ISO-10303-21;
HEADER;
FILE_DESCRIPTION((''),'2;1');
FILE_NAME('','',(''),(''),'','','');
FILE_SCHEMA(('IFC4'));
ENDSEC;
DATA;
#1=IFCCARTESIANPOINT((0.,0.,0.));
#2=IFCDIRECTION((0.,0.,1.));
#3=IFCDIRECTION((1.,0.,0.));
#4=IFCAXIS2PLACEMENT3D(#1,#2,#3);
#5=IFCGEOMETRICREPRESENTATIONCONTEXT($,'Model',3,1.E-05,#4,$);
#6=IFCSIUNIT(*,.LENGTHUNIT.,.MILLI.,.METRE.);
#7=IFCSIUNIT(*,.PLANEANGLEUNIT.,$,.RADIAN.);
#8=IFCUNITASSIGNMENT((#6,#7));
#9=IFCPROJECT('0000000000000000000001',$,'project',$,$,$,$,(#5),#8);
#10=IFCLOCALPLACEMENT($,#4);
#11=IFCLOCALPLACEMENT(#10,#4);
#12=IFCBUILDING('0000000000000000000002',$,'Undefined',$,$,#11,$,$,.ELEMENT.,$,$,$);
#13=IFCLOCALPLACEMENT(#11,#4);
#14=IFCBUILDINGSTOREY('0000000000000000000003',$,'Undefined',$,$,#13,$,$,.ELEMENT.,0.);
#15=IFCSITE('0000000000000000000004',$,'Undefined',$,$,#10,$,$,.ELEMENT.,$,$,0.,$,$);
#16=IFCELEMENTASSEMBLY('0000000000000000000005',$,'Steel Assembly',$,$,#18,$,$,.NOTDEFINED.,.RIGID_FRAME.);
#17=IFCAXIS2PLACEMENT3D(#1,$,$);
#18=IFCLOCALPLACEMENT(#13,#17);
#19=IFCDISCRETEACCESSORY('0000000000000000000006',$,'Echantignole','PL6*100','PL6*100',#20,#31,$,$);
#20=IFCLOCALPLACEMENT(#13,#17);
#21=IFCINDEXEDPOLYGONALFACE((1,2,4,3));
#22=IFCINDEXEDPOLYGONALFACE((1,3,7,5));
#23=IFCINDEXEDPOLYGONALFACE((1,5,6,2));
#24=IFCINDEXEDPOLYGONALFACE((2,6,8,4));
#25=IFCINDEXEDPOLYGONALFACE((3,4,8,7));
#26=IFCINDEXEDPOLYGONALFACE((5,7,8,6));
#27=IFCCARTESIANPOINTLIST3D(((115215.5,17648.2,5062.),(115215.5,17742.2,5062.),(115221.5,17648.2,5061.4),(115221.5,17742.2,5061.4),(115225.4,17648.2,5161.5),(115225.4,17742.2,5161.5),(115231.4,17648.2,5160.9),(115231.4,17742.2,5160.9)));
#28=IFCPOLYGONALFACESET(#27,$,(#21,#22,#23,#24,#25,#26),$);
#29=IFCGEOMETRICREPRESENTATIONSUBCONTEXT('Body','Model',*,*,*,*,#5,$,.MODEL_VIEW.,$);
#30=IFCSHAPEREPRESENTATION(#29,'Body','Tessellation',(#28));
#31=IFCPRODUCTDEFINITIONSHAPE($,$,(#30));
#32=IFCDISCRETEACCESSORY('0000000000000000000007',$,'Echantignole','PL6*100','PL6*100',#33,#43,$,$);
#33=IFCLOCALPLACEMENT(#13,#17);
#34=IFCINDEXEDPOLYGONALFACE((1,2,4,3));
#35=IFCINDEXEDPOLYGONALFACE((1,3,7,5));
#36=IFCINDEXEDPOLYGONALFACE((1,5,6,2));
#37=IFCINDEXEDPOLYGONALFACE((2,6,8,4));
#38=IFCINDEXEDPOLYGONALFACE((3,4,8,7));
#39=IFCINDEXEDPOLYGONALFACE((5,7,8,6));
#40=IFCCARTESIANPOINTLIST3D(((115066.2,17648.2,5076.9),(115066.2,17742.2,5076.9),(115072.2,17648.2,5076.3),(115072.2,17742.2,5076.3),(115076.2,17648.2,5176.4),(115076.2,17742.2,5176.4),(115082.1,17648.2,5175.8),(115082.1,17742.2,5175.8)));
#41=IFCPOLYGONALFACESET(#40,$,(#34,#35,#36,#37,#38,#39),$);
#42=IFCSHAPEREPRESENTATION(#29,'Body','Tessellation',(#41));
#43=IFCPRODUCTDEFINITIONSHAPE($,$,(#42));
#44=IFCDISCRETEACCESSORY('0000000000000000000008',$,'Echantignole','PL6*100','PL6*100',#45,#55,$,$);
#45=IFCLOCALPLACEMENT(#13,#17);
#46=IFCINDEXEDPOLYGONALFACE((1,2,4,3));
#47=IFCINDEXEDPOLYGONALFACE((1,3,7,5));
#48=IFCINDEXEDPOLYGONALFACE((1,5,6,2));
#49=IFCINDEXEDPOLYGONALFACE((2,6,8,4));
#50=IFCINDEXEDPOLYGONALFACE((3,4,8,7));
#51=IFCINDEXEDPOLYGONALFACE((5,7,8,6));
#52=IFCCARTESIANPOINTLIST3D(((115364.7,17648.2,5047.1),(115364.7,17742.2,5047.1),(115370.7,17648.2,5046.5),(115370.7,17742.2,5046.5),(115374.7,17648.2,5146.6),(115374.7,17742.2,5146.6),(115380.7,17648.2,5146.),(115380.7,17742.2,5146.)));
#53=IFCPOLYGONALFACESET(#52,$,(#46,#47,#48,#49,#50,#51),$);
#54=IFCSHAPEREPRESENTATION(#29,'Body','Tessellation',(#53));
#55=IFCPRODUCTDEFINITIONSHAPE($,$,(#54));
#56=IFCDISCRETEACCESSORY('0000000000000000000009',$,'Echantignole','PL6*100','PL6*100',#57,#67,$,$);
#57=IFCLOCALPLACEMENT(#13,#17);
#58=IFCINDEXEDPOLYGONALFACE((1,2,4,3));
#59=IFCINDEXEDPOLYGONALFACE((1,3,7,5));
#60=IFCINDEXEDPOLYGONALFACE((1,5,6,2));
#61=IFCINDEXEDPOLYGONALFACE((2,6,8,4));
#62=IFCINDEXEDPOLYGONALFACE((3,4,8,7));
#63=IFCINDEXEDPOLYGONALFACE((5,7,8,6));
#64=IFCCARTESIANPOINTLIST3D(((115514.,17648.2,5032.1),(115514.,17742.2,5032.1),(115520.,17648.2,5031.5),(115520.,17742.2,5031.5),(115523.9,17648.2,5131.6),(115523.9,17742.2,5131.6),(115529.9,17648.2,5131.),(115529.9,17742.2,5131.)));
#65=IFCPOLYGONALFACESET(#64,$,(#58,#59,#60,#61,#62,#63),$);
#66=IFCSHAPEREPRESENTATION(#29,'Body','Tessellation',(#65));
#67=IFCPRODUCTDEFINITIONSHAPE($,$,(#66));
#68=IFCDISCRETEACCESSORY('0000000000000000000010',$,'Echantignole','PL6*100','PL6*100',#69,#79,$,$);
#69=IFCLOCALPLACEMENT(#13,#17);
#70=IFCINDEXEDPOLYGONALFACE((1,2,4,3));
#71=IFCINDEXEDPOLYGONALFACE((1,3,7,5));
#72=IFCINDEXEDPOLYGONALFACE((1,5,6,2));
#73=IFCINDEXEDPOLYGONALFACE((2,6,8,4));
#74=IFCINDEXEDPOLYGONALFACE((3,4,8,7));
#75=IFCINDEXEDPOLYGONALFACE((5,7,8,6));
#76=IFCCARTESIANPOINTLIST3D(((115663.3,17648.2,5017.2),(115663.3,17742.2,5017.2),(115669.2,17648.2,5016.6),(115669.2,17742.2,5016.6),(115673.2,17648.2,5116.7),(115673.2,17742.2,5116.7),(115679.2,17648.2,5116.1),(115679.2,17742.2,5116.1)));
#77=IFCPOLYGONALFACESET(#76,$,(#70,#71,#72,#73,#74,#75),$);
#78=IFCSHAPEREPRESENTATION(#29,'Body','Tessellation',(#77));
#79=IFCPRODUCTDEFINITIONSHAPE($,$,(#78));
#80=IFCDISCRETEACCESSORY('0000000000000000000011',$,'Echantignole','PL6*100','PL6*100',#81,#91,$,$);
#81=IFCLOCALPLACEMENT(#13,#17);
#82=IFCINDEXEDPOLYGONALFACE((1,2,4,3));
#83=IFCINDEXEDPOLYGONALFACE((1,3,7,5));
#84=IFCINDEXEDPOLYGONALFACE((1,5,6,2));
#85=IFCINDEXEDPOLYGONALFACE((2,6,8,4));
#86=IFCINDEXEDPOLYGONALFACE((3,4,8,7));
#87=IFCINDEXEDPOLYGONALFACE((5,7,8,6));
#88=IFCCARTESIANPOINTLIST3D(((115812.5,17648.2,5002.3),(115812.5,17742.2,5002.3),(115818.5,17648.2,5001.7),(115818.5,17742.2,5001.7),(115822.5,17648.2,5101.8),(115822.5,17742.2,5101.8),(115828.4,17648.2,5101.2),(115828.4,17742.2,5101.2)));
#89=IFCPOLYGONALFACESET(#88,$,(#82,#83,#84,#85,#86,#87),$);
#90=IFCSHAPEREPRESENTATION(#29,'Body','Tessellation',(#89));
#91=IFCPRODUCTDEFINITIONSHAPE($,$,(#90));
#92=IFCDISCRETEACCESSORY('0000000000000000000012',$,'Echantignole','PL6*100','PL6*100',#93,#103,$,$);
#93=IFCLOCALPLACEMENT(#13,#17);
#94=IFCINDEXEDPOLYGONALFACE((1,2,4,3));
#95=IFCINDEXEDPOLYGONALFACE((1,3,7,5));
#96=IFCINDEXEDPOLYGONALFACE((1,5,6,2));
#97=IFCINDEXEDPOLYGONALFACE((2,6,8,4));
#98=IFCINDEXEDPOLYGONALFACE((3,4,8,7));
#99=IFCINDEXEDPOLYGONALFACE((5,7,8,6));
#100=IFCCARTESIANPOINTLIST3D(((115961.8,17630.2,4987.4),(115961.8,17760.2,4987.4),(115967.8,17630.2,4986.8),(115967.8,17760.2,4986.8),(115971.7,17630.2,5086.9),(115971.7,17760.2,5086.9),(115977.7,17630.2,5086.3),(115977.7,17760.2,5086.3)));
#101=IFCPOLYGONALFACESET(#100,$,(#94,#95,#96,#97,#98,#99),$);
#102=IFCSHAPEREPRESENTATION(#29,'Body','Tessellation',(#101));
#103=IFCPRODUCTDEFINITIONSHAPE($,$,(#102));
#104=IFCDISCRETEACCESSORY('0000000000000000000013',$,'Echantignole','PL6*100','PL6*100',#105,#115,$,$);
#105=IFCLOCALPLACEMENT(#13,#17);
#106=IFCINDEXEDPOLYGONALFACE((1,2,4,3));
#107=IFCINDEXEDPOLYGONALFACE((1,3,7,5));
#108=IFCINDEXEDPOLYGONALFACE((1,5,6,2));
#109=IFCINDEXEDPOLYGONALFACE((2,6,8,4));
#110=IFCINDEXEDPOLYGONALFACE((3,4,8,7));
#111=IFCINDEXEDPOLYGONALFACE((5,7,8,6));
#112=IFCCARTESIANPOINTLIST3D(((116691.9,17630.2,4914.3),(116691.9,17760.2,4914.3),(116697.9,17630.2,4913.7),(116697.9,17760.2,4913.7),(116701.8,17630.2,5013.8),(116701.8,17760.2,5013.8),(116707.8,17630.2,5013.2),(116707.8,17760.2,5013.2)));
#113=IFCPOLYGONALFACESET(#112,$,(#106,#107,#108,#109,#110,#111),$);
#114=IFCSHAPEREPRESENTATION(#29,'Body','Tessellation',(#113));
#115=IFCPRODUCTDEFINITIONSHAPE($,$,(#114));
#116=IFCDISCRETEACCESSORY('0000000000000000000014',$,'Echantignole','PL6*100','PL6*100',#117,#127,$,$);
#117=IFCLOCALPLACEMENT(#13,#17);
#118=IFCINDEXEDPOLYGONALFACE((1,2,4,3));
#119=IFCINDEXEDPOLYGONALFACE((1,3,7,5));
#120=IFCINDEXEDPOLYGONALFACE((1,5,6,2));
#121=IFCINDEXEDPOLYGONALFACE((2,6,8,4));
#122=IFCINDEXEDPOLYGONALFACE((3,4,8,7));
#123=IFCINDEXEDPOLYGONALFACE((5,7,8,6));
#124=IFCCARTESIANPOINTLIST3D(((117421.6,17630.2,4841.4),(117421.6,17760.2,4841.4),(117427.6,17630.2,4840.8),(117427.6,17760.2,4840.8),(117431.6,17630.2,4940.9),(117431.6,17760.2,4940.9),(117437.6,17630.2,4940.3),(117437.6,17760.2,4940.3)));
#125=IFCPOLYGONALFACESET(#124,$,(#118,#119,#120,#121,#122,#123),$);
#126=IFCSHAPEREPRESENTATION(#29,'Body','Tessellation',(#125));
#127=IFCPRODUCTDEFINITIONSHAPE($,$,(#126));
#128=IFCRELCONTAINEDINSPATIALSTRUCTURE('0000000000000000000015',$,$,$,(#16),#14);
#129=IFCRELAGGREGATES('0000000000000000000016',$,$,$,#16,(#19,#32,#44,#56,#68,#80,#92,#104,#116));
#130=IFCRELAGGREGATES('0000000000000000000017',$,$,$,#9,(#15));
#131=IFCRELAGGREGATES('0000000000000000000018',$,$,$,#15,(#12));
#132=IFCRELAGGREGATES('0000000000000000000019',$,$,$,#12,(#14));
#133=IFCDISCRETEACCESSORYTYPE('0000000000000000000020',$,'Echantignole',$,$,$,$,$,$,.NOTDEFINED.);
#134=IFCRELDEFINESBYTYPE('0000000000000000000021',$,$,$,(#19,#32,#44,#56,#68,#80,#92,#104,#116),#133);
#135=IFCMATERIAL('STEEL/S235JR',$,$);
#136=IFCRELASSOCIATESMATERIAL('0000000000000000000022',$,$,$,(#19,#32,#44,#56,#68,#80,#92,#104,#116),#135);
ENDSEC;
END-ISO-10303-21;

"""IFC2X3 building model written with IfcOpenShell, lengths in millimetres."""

from ifc_helpers import new_model, si_unit, frame, origin_with_axes, place, context, subcontext, project, spatial, polyline, outline, extrude, material, type_object, element, aggregate, save


model = new_model("IFC2X3")

# Units and contexts
model_context = context("Model", 3, precision=1e-05, world=origin_with_axes())
body_context = subcontext(model_context, "Body", "Model", "MODEL_VIEW")
ifc_project = project(units=[si_unit("LENGTHUNIT", "METRE", prefix="MILLI"), si_unit("PLANEANGLEUNIT", "RADIAN")], contexts=[model_context])

# Site, building, storey
site_placement = place(None, origin_with_axes())
site = spatial("IfcSite", under=ifc_project, at=site_placement, Name="Undefined", CompositionType="ELEMENT", RefElevation=0.0)
building_placement = place(site_placement, origin_with_axes())
building = spatial("IfcBuilding", under=site, at=building_placement, Name="Undefined", CompositionType="ELEMENT")
storey_placement = place(building_placement, origin_with_axes())
storey = spatial("IfcBuildingStorey", under=building, at=storey_placement, Name="Undefined", CompositionType="ELEMENT", Elevation=0.0)

# Element assembly, discrete accessories
assembly_1_placement = place(storey_placement, origin_with_axes())
assembly_1 = element("IfcElementAssembly", 1, at=assembly_1_placement, inside=storey, Name="Steel Assembly", AssemblyPlace="NOTDEFINED", PredefinedType="RIGID_FRAME")
ifc_material_1 = material(Name="STEEL/S235JR")
discrete_accessory_type_1 = type_object("IfcDiscreteAccessoryType", Name="Echantignole")
discrete_accessory_1_placement = place(assembly_1_placement, frame((115223.4, 17648.2, 5111.4), z_axis=(0.995037, 0.0, -0.099504), x_axis=(0.0, 1.0, 0.000001)))
discrete_accessory_1 = element("IfcDiscreteAccessory", 2, at=discrete_accessory_1_placement, type_object=discrete_accessory_type_1, material=ifc_material_1, Name="Echantignole", Description="PL6*100", ObjectType="PL6*100", context=body_context, shape_type="SweptSolid", body=[
    extrude(outline(polyline([(0.0, 50.0), (94.0, 50.0), (94.0, -50.0), (0.0, -50.0), (0.0, 50.0)])), frame((0.0, 0.0, -3.0), z_axis=(0.0, 0.0, 1.0), x_axis=(1.0, 0.0, 0.0)), (0.0, 0.0, 1.0), 6.0),
])
discrete_accessory_2_placement = place(assembly_1_placement, frame((115074.2, 17648.2, 5126.4), z_axis=(0.995037, 0.0, -0.099504), x_axis=(0.0, 1.0, 0.000001)))
discrete_accessory_2 = element("IfcDiscreteAccessory", 3, at=discrete_accessory_2_placement, type_object=discrete_accessory_type_1, material=ifc_material_1, Name="Echantignole", Description="PL6*100", ObjectType="PL6*100", context=body_context, shape_type="SweptSolid", body=[
    extrude(outline(polyline([(0.0, 50.0), (94.0, 50.0), (94.0, -50.0), (0.0, -50.0), (0.0, 50.0)])), frame((0.0, 0.0, -3.0), z_axis=(0.0, 0.0, 1.0), x_axis=(1.0, 0.0, 0.0)), (0.0, 0.0, 1.0), 6.0),
])
discrete_accessory_3_placement = place(assembly_1_placement, frame((115372.7, 17648.2, 5096.5), z_axis=(0.995037, 0.0, -0.099504), x_axis=(0.0, 1.0, 0.000001)))
discrete_accessory_3 = element("IfcDiscreteAccessory", 4, at=discrete_accessory_3_placement, type_object=discrete_accessory_type_1, material=ifc_material_1, Name="Echantignole", Description="PL6*100", ObjectType="PL6*100", context=body_context, shape_type="SweptSolid", body=[
    extrude(outline(polyline([(0.0, 50.0), (94.0, 50.0), (94.0, -50.0), (0.0, -50.0), (0.0, 50.0)])), frame((0.0, 0.0, -3.0), z_axis=(0.0, 0.0, 1.0), x_axis=(1.0, 0.0, 0.0)), (0.0, 0.0, 1.0), 6.0),
])
discrete_accessory_4_placement = place(assembly_1_placement, frame((115522.0, 17648.2, 5081.6), z_axis=(0.995037, 0.0, -0.099504), x_axis=(0.0, 1.0, 0.000001)))
discrete_accessory_4 = element("IfcDiscreteAccessory", 5, at=discrete_accessory_4_placement, type_object=discrete_accessory_type_1, material=ifc_material_1, Name="Echantignole", Description="PL6*100", ObjectType="PL6*100", context=body_context, shape_type="SweptSolid", body=[
    extrude(outline(polyline([(0.0, 50.0), (94.0, 50.0), (94.0, -50.0), (0.0, -50.0), (0.0, 50.0)])), frame((0.0, 0.0, -3.0), z_axis=(0.0, 0.0, 1.0), x_axis=(1.0, 0.0, 0.0)), (0.0, 0.0, 1.0), 6.0),
])
discrete_accessory_5_placement = place(assembly_1_placement, frame((115671.2, 17648.2, 5066.7), z_axis=(0.995037, 0.0, -0.099504), x_axis=(0.0, 1.0, 0.000001)))
discrete_accessory_5 = element("IfcDiscreteAccessory", 6, at=discrete_accessory_5_placement, type_object=discrete_accessory_type_1, material=ifc_material_1, Name="Echantignole", Description="PL6*100", ObjectType="PL6*100", context=body_context, shape_type="SweptSolid", body=[
    extrude(outline(polyline([(0.0, 50.0), (94.0, 50.0), (94.0, -50.0), (0.0, -50.0), (0.0, 50.0)])), frame((0.0, 0.0, -3.0), z_axis=(0.0, 0.0, 1.0), x_axis=(1.0, 0.0, 0.0)), (0.0, 0.0, 1.0), 6.0),
])
discrete_accessory_6_placement = place(assembly_1_placement, frame((115820.5, 17648.2, 5051.7), z_axis=(0.995037, 0.0, -0.099504), x_axis=(0.0, 1.0, 0.000001)))
discrete_accessory_6 = element("IfcDiscreteAccessory", 7, at=discrete_accessory_6_placement, type_object=discrete_accessory_type_1, material=ifc_material_1, Name="Echantignole", Description="PL6*100", ObjectType="PL6*100", context=body_context, shape_type="SweptSolid", body=[
    extrude(outline(polyline([(0.0, 50.0), (94.0, 50.0), (94.0, -50.0), (0.0, -50.0), (0.0, 50.0)])), frame((0.0, 0.0, -3.0), z_axis=(0.0, 0.0, 1.0), x_axis=(1.0, 0.0, 0.0)), (0.0, 0.0, 1.0), 6.0),
])
discrete_accessory_7_placement = place(assembly_1_placement, frame((115969.7, 17630.2, 5036.8), z_axis=(0.995037, 0.0, -0.099504), x_axis=(0.0, 1.0, 0.000001)))
discrete_accessory_7 = element("IfcDiscreteAccessory", 8, at=discrete_accessory_7_placement, type_object=discrete_accessory_type_1, material=ifc_material_1, Name="Echantignole", Description="PL6*100", ObjectType="PL6*100", context=body_context, shape_type="SweptSolid", body=[
    extrude(outline(polyline([(0.0, 50.0), (130.0, 50.0), (130.0, -50.0), (0.0, -50.0), (0.0, 50.0)])), frame((0.0, 0.0, -3.0), z_axis=(0.0, 0.0, 1.0), x_axis=(1.0, 0.0, 0.0)), (0.0, 0.0, 1.0), 6.0),
])
discrete_accessory_8_placement = place(assembly_1_placement, frame((116699.8, 17630.2, 4963.8), z_axis=(0.995037, 0.0, -0.099504), x_axis=(0.0, 1.0, 0.000001)))
discrete_accessory_8 = element("IfcDiscreteAccessory", 9, at=discrete_accessory_8_placement, type_object=discrete_accessory_type_1, material=ifc_material_1, Name="Echantignole", Description="PL6*100", ObjectType="PL6*100", context=body_context, shape_type="SweptSolid", body=[
    extrude(outline(polyline([(0.0, 50.0), (130.0, 50.0), (130.0, -50.0), (0.0, -50.0), (0.0, 50.0)])), frame((0.0, 0.0, -3.0), z_axis=(0.0, 0.0, 1.0), x_axis=(1.0, 0.0, 0.0)), (0.0, 0.0, 1.0), 6.0),
])
discrete_accessory_9_placement = place(assembly_1_placement, frame((117429.6, 17630.2, 4890.8), z_axis=(0.995037, 0.0, -0.099504), x_axis=(0.0, 1.0, 0.000001)))
discrete_accessory_9 = element("IfcDiscreteAccessory", 10, at=discrete_accessory_9_placement, type_object=discrete_accessory_type_1, material=ifc_material_1, Name="Echantignole", Description="PL6*100", ObjectType="PL6*100", context=body_context, shape_type="SweptSolid", body=[
    extrude(outline(polyline([(0.0, 50.0), (130.0, 50.0), (130.0, -50.0), (0.0, -50.0), (0.0, 50.0)])), frame((0.0, 0.0, -3.0), z_axis=(0.0, 0.0, 1.0), x_axis=(1.0, 0.0, 0.0)), (0.0, 0.0, 1.0), 6.0),
])
aggregate(assembly_1, [discrete_accessory_1, discrete_accessory_2, discrete_accessory_3, discrete_accessory_4, discrete_accessory_5, discrete_accessory_6, discrete_accessory_7, discrete_accessory_8, discrete_accessory_9])

save(model, "model.ifc")
